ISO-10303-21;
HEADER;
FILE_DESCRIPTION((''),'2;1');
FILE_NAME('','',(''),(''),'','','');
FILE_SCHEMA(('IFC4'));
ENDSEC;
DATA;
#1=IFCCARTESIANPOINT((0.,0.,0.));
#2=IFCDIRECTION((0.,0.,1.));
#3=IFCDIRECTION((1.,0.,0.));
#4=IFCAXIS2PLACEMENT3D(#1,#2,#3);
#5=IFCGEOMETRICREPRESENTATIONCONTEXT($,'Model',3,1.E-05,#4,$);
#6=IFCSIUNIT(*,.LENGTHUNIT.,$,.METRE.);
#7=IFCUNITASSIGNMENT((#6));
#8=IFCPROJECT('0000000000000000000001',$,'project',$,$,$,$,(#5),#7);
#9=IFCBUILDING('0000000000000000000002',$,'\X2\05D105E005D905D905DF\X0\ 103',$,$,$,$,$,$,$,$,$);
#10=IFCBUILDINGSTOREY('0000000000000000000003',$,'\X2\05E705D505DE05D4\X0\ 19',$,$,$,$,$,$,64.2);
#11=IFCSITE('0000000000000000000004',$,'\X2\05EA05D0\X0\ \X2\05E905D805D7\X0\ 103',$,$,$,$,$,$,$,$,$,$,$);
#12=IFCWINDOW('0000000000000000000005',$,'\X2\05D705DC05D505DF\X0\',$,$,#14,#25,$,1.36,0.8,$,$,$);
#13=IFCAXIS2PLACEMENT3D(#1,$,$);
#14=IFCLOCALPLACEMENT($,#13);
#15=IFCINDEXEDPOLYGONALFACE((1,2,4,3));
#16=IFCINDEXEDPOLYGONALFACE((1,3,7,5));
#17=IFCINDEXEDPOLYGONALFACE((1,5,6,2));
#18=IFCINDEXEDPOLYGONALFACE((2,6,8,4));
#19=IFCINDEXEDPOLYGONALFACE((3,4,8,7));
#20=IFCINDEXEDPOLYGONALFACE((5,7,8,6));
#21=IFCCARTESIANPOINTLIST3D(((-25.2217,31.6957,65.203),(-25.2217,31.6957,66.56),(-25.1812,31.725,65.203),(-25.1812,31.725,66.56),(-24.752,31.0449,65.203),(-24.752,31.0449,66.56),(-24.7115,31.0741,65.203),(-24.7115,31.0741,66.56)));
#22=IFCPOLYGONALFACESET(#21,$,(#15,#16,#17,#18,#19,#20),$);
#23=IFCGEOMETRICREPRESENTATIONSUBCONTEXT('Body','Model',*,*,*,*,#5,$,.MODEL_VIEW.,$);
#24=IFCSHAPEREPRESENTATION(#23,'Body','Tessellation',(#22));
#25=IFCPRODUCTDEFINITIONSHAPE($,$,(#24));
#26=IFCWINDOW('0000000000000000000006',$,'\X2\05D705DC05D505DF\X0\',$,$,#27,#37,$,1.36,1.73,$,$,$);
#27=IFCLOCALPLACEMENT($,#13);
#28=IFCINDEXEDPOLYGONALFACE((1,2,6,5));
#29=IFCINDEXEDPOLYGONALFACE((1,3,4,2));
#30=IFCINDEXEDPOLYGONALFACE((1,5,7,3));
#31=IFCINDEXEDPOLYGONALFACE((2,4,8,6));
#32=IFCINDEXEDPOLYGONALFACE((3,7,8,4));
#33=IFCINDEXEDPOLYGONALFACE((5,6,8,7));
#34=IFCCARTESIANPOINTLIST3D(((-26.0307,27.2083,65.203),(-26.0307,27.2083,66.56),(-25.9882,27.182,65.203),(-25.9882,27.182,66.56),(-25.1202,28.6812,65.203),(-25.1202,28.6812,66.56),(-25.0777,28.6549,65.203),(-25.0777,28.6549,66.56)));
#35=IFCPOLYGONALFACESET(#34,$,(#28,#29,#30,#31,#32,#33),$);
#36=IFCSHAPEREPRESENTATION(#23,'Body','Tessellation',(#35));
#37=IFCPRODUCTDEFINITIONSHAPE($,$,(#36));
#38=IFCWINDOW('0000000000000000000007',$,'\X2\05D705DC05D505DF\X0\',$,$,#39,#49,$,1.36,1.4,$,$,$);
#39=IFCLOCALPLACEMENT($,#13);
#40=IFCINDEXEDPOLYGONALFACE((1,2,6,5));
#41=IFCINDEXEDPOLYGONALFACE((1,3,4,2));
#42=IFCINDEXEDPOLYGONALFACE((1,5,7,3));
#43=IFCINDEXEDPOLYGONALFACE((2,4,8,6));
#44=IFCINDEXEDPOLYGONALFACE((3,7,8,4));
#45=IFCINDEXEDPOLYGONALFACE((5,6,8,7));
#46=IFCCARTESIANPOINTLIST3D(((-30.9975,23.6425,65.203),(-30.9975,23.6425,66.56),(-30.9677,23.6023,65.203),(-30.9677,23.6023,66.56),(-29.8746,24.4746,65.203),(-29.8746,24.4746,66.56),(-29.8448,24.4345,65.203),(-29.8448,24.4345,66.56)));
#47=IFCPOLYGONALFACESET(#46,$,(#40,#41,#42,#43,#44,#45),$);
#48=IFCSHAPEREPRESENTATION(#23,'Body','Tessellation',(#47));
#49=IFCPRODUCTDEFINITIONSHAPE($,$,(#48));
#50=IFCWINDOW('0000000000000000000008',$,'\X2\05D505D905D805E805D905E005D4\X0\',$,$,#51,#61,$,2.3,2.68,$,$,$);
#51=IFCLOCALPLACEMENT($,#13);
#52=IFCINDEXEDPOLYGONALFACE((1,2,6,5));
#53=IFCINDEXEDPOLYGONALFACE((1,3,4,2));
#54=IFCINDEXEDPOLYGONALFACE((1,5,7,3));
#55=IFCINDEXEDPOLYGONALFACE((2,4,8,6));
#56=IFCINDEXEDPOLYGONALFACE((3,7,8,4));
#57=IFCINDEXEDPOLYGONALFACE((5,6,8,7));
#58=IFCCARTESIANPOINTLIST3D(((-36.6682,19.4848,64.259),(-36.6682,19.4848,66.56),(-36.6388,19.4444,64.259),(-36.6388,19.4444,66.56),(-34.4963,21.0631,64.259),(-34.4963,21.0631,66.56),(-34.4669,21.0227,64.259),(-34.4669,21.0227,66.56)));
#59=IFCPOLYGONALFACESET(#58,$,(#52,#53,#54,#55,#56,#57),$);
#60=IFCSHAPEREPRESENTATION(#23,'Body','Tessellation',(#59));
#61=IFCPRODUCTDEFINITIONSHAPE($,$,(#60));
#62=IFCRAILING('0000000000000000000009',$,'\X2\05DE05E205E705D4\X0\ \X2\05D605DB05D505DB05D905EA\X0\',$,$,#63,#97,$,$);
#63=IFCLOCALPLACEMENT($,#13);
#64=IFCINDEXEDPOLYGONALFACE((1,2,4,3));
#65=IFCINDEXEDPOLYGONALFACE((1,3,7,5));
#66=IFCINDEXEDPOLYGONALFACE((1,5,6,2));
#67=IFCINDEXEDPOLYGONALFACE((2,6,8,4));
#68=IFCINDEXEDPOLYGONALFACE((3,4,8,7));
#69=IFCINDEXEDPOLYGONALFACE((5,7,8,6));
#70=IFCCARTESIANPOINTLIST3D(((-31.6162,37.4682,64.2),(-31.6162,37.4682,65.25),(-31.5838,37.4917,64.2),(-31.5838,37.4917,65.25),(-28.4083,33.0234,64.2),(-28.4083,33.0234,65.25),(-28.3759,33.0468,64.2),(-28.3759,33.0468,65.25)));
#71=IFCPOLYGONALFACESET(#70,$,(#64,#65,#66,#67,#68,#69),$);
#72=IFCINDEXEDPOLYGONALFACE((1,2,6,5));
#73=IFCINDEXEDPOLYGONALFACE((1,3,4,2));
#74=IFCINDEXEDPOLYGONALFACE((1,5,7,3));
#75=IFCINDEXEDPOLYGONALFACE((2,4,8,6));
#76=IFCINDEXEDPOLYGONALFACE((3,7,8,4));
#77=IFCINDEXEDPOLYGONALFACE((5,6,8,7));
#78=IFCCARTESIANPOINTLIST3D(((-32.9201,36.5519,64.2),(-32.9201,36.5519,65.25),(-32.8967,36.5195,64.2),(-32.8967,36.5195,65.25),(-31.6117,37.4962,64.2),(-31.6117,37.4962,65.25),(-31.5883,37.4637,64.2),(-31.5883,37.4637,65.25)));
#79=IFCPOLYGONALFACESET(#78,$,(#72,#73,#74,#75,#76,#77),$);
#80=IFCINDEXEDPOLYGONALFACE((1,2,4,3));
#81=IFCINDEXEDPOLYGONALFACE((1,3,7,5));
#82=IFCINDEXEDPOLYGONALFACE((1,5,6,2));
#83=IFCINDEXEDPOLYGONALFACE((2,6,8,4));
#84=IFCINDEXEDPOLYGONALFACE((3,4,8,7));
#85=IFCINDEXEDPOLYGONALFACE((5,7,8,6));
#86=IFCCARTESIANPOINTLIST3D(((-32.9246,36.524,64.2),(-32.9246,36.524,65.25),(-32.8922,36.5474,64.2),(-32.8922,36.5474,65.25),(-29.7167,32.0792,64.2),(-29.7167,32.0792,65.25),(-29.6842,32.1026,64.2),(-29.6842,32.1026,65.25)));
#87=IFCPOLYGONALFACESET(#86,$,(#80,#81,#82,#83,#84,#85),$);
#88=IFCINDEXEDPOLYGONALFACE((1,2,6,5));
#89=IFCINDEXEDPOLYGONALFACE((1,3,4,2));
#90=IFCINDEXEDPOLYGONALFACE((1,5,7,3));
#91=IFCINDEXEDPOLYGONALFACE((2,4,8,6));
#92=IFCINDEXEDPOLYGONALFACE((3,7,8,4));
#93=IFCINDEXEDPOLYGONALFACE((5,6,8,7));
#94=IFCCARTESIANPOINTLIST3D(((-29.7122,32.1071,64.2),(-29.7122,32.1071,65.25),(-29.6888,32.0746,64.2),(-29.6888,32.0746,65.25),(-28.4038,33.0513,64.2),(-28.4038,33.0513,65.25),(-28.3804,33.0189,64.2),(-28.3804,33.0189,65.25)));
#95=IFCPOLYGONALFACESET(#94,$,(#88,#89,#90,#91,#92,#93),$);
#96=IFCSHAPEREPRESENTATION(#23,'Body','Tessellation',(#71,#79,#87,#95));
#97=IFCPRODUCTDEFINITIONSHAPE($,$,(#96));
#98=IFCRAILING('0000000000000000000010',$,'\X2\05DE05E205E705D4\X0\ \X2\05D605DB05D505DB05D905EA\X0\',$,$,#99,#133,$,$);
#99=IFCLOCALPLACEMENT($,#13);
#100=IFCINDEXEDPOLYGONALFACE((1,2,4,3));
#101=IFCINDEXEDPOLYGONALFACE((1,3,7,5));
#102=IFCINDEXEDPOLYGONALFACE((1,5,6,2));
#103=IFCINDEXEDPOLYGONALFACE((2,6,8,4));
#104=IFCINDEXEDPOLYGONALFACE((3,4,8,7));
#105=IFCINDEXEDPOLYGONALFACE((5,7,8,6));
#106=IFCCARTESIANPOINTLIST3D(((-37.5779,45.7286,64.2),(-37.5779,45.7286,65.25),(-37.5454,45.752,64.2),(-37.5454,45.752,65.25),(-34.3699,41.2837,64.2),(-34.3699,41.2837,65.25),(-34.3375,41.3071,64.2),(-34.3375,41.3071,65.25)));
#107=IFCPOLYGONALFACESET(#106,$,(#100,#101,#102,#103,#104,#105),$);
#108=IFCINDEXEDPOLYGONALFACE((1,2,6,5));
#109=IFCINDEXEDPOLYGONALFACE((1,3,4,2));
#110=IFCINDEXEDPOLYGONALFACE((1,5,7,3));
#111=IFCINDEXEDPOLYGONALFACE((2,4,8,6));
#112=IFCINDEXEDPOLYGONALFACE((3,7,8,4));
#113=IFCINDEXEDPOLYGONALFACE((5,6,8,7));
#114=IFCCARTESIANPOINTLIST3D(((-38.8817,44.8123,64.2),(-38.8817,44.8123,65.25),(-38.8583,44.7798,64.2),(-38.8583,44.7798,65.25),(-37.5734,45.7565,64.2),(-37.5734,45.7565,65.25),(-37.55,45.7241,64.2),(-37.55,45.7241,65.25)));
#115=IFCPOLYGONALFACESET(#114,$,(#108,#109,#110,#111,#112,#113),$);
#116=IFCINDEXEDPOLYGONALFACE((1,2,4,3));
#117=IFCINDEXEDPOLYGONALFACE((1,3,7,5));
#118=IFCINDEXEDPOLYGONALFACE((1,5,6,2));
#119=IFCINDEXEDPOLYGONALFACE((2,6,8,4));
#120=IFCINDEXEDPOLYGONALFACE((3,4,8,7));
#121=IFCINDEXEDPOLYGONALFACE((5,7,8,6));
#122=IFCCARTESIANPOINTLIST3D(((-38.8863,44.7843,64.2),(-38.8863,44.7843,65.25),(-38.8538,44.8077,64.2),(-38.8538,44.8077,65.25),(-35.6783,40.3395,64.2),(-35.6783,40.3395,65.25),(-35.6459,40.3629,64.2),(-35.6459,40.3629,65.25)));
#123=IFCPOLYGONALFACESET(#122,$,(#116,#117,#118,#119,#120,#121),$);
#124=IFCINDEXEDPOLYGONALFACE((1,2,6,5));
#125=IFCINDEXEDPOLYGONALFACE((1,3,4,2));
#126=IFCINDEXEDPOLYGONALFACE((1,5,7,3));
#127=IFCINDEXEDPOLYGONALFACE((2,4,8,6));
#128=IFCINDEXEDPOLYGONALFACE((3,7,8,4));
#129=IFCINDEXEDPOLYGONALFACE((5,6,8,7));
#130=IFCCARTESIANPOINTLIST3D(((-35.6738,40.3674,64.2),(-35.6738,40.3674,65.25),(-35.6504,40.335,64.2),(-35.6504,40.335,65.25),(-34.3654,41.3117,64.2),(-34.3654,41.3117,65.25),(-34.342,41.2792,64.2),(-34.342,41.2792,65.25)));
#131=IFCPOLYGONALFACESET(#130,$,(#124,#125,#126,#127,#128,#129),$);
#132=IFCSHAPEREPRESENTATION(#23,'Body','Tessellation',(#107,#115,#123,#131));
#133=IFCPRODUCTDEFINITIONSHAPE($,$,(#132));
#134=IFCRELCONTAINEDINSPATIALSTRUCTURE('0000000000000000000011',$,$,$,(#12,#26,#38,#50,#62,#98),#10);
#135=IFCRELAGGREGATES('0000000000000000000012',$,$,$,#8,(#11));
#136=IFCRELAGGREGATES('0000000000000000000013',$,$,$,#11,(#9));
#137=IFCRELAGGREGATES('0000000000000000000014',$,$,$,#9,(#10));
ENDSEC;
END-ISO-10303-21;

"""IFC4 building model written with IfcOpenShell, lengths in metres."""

from ifc_helpers import new_model, si_unit, frame, origin_with_axes, context, subcontext, project, spatial, polyline, outline, extrude, element, save


model = new_model("IFC4")

# Units and contexts
model_context = context("Model", 3, precision=1e-05, world=origin_with_axes())
body_context = subcontext(model_context, "Body", "Model", "MODEL_VIEW")
ifc_project = project(units=[si_unit("LENGTHUNIT", "METRE")], contexts=[model_context])

# Site, building, storey
site = spatial("IfcSite", under=ifc_project, Name="תא שטח 103")
building = spatial("IfcBuilding", under=site, Name="בניין 103")
storey = spatial("IfcBuildingStorey", under=building, Name="קומה 19", Elevation=64.2)

# Windows
element("IfcWindow", 1, inside=storey, Name="חלון", OverallHeight=1.36, OverallWidth=0.8, context=body_context, shape_type="SweptSolid", body=[
    extrude(outline(polyline([(-25.2217, 31.6957), (-24.752, 31.0449), (-24.7115, 31.0741), (-25.1812, 31.725), (-25.2217, 31.6957)])), frame((0.0, 0.0, 65.203)), (0.0, 0.0, 1.0), 1.357),
])
element("IfcWindow", 2, inside=storey, Name="חלון", OverallHeight=1.36, OverallWidth=1.73, context=body_context, shape_type="SweptSolid", body=[
    extrude(outline(polyline([(-25.1202, 28.6812), (-26.0307, 27.2083), (-25.9882, 27.182), (-25.0777, 28.6549), (-25.1202, 28.6812)])), frame((0.0, 0.0, 65.203)), (0.0, 0.0, 1.0), 1.357),
])
element("IfcWindow", 3, inside=storey, Name="חלון", OverallHeight=1.36, OverallWidth=1.4, context=body_context, shape_type="SweptSolid", body=[
    extrude(outline(polyline([(-29.8746, 24.4746), (-30.9975, 23.6425), (-30.9677, 23.6023), (-29.8448, 24.4345), (-29.8746, 24.4746)])), frame((0.0, 0.0, 65.203)), (0.0, 0.0, 1.0), 1.357),
])
element("IfcWindow", 4, inside=storey, Name="ויטרינה", OverallHeight=2.3, OverallWidth=2.68, context=body_context, shape_type="SweptSolid", body=[
    extrude(outline(polyline([(-34.4963, 21.0631), (-36.6682, 19.4848), (-36.6388, 19.4444), (-34.4669, 21.0227), (-34.4963, 21.0631)])), frame((0.0, 0.0, 64.259)), (0.0, 0.0, 1.0), 2.301),
])

# Railings
element("IfcRailing", 5, inside=storey, Name="מעקה זכוכית", context=body_context, shape_type="SweptSolid", body=[
    extrude(outline(polyline([(-28.3759, 33.0468), (-31.5838, 37.4917), (-31.6162, 37.4682), (-28.4083, 33.0234), (-28.3759, 33.0468)])), frame((0.0, 0.0, 64.2)), (0.0, 0.0, 1.0), 1.05),
    extrude(outline(polyline([(-31.6117, 37.4962), (-32.9201, 36.5519), (-32.8967, 36.5195), (-31.5883, 37.4637), (-31.6117, 37.4962)])), frame((0.0, 0.0, 64.2)), (0.0, 0.0, 1.0), 1.05),
    extrude(outline(polyline([(-32.9246, 36.524), (-29.7167, 32.0792), (-29.6842, 32.1026), (-32.8922, 36.5474), (-32.9246, 36.524)])), frame((0.0, 0.0, 64.2)), (0.0, 0.0, 1.0), 1.05),
    extrude(outline(polyline([(-29.6888, 32.0746), (-28.3804, 33.0189), (-28.4038, 33.0513), (-29.7122, 32.1071), (-29.6888, 32.0746)])), frame((0.0, 0.0, 64.2)), (0.0, 0.0, 1.0), 1.05),
])
element("IfcRailing", 6, inside=storey, Name="מעקה זכוכית", context=body_context, shape_type="SweptSolid", body=[
    extrude(outline(polyline([(-34.3375, 41.3071), (-37.5454, 45.752), (-37.5779, 45.7286), (-34.3699, 41.2837), (-34.3375, 41.3071)])), frame((0.0, 0.0, 64.2)), (0.0, 0.0, 1.0), 1.05),
    extrude(outline(polyline([(-37.5734, 45.7565), (-38.8817, 44.8123), (-38.8583, 44.7798), (-37.55, 45.7241), (-37.5734, 45.7565)])), frame((0.0, 0.0, 64.2)), (0.0, 0.0, 1.0), 1.05),
    extrude(outline(polyline([(-38.8863, 44.7843), (-35.6783, 40.3395), (-35.6459, 40.3629), (-38.8538, 44.8077), (-38.8863, 44.7843)])), frame((0.0, 0.0, 64.2)), (0.0, 0.0, 1.0), 1.05),
    extrude(outline(polyline([(-35.6504, 40.335), (-34.342, 41.2792), (-34.3654, 41.3117), (-35.6738, 40.3674), (-35.6504, 40.335)])), frame((0.0, 0.0, 64.2)), (0.0, 0.0, 1.0), 1.05),
])

save(model, "model.ifc")
